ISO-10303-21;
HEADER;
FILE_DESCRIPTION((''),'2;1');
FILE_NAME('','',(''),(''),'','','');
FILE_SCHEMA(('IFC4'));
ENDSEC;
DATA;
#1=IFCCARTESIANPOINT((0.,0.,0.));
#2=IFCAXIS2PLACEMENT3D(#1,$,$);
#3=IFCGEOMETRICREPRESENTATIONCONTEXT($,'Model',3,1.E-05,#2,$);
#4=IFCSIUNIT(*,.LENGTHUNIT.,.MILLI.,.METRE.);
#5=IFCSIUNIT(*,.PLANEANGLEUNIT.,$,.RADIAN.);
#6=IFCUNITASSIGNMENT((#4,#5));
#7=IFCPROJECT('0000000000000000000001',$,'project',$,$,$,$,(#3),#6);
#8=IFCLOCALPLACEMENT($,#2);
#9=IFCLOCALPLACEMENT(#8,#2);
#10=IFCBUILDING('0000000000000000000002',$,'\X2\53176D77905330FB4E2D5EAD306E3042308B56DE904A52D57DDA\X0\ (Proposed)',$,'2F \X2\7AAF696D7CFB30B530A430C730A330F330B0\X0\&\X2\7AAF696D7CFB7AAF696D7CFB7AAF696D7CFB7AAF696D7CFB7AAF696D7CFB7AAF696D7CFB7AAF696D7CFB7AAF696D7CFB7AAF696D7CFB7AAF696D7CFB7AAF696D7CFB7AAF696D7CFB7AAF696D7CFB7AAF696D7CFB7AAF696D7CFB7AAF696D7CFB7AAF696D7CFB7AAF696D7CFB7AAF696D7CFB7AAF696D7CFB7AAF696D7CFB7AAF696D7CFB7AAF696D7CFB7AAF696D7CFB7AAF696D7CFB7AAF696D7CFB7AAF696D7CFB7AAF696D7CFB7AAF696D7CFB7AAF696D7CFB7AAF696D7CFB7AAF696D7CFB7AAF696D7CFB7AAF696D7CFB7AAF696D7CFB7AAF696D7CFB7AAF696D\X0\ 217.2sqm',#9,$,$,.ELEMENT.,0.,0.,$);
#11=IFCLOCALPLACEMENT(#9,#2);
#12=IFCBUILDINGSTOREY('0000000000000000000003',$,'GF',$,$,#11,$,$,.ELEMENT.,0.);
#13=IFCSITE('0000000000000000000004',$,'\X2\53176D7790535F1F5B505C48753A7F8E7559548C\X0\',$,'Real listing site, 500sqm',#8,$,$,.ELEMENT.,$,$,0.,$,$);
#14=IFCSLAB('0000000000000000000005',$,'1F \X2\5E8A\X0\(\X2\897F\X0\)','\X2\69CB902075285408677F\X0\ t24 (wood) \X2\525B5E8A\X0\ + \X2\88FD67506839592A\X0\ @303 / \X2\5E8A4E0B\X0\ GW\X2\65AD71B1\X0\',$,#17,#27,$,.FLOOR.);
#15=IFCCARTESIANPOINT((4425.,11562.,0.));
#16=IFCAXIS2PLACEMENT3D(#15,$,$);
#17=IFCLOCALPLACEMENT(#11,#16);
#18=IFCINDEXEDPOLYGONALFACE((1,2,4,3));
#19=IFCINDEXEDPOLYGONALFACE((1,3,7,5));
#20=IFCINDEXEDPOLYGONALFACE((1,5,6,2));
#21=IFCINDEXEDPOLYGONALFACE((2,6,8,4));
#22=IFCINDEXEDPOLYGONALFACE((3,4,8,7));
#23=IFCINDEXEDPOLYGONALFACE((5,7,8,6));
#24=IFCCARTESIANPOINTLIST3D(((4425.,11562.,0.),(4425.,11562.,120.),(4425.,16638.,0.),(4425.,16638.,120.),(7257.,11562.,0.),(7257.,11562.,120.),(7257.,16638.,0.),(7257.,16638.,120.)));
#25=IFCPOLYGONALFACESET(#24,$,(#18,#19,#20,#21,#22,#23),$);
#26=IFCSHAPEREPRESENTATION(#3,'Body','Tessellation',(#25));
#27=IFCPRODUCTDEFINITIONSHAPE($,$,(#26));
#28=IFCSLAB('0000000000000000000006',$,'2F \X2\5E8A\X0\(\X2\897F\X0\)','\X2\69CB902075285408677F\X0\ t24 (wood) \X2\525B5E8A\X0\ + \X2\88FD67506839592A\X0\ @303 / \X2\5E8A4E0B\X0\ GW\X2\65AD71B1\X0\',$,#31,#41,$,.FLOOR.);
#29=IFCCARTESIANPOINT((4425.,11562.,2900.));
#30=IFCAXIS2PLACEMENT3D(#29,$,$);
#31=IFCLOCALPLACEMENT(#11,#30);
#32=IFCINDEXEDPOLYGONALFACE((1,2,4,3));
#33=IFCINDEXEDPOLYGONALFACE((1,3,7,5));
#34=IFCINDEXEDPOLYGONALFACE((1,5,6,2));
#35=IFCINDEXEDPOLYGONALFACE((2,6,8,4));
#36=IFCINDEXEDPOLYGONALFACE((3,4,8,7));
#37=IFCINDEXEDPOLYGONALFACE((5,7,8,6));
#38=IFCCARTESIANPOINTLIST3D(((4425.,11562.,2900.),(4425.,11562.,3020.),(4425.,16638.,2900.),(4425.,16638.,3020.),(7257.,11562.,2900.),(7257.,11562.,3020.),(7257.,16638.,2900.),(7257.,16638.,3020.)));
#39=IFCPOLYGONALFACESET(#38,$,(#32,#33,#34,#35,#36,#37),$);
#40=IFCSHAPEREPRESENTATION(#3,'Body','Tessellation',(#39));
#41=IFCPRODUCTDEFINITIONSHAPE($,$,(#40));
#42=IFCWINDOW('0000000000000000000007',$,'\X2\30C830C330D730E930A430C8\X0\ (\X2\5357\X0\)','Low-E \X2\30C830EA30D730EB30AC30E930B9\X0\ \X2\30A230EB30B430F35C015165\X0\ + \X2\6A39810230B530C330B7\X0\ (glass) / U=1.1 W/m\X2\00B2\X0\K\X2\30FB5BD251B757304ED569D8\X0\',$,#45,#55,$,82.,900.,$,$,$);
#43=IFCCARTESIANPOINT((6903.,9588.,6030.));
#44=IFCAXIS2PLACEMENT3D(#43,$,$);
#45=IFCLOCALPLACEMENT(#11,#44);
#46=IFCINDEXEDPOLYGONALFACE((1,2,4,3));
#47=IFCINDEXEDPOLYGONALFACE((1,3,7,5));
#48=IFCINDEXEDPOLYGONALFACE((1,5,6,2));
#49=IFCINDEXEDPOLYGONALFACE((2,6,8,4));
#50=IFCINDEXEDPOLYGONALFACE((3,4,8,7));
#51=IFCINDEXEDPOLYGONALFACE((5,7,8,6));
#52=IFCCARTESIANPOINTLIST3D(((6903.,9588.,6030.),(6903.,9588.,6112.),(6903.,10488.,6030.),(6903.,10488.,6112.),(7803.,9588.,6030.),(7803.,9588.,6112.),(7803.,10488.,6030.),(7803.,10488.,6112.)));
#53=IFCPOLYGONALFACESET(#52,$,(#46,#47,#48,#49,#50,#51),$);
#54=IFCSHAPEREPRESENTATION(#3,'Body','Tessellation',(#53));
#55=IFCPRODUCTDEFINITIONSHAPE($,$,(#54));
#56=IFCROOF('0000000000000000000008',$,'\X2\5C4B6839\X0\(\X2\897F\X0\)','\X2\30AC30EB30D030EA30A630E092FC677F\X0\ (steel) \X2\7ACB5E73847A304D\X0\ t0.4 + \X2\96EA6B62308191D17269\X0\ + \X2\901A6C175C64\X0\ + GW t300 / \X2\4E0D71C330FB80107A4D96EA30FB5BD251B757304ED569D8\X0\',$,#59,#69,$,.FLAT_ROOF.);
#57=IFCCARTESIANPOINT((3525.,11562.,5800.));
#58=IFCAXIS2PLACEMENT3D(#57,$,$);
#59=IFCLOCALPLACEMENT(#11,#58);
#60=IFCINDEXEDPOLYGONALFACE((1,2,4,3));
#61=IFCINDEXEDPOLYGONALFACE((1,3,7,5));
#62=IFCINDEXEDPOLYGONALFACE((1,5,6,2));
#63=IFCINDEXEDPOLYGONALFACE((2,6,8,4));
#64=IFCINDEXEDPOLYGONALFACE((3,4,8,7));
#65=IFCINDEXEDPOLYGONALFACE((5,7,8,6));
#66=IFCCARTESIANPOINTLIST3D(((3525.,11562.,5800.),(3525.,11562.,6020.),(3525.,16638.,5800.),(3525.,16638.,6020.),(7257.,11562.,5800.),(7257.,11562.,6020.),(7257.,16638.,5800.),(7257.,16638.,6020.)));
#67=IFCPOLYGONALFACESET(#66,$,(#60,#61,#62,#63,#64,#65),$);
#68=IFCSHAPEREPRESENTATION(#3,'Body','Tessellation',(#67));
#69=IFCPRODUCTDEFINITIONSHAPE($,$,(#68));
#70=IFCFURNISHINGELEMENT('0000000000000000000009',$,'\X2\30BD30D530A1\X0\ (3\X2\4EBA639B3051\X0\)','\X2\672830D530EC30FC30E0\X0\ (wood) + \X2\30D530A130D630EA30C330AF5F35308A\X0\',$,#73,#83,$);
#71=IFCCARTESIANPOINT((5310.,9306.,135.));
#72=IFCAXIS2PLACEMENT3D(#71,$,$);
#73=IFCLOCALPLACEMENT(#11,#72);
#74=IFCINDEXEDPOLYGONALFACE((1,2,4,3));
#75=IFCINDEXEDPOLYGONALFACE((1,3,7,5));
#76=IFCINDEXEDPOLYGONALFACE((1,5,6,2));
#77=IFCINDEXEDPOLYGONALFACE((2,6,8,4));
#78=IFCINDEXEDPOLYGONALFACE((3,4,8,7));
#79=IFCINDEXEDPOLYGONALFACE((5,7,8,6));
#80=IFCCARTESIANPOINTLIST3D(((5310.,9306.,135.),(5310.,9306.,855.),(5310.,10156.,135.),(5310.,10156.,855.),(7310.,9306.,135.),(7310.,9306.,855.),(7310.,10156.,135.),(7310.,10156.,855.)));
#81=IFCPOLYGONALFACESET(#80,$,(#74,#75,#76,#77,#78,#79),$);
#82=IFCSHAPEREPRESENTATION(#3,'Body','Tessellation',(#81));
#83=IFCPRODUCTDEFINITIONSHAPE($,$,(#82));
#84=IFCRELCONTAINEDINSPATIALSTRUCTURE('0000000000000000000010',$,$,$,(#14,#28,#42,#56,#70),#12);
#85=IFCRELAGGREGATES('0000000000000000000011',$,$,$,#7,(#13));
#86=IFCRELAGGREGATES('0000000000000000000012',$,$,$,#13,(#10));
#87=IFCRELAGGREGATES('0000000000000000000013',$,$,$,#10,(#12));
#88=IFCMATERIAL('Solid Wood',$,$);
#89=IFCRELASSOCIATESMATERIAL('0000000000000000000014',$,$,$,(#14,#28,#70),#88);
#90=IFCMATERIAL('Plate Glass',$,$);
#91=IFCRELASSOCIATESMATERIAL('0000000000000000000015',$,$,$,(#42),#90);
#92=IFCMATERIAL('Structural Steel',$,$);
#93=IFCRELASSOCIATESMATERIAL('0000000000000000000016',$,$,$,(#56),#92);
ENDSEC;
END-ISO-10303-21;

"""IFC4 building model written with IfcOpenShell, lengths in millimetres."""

from ifc_helpers import new_model, si_unit, frame, frame_2d, origin, place, context, project, spatial, rectangle, extrude, material, element, save


model = new_model("IFC4")

# Units and contexts
model_context = context("Model", 3, precision=1e-05, world=origin())
ifc_project = project(units=[si_unit("LENGTHUNIT", "METRE", prefix="MILLI"), si_unit("PLANEANGLEUNIT", "RADIAN")], contexts=[model_context])

# Site, building, storey
site_placement = place(None, origin())
site = spatial("IfcSite", under=ifc_project, at=site_placement, Name="北海道弟子屈町美留和", ObjectType="Real listing site, 500sqm", CompositionType="ELEMENT", RefElevation=0.0)
building_placement = place(site_placement, origin())
building = spatial("IfcBuilding", under=site, at=building_placement, Name="北海道・中庭のある回遊動線 (Proposed)", ObjectType="2F 窯業系サイディング&窯業系窯業系窯業系窯業系窯業系窯業系窯業系窯業系窯業系窯業系窯業系窯業系窯業系窯業系窯業系窯業系窯業系窯業系窯業系窯業系窯業系窯業系窯業系窯業系窯業系窯業系窯業系窯業系窯業系窯業系窯業系窯業系窯業系窯業系窯業系窯業系窯業 217.2sqm", CompositionType="ELEMENT", ElevationOfRefHeight=0.0, ElevationOfTerrain=0.0)
storey_placement = place(building_placement, origin())
storey = spatial("IfcBuildingStorey", under=building, at=storey_placement, Name="GF", CompositionType="ELEMENT", Elevation=0.0)

# Shared definitions
ifc_material_1 = material(Name="Solid Wood")

# Slabs
slab_1_placement = place(storey_placement, frame((4425.0, 11562.0, 0.0)))
element("IfcSlab", 1, at=slab_1_placement, inside=storey, material=ifc_material_1, Name="1F 床(西)", Description="構造用合板 t24 (wood) 剛床 + 製材根太 @303 / 床下 GW断熱", PredefinedType="FLOOR", context=model_context, shape_type="SweptSolid", body=[
    extrude(rectangle(XDim=2832.0, YDim=5076.0, at=frame_2d((1416.0, 2538.0))), frame((4425.0, 11562.0, 0.0)), (0.0, 0.0, 1.0), 120.0),
])
slab_2_placement = place(storey_placement, frame((4425.0, 11562.0, 2900.0)))
element("IfcSlab", 2, at=slab_2_placement, inside=storey, material=ifc_material_1, Name="2F 床(西)", Description="構造用合板 t24 (wood) 剛床 + 製材根太 @303 / 床下 GW断熱", PredefinedType="FLOOR", context=model_context, shape_type="SweptSolid", body=[
    extrude(rectangle(XDim=2832.0, YDim=5076.0, at=frame_2d((1416.0, 2538.0))), frame((4425.0, 11562.0, 2900.0)), (0.0, 0.0, 1.0), 120.0),
])

# Window
ifc_material_2 = material(Name="Plate Glass")
window_placement = place(storey_placement, frame((6903.0, 9588.0, 6030.0)))
element("IfcWindow", 3, at=window_placement, inside=storey, material=ifc_material_2, Name="トップライト (南)", Description="Low-E トリプルガラス アルゴン封入 + 樹脂サッシ (glass) / U=1.1 W/m²K・寒冷地仕様", OverallHeight=82.0, OverallWidth=900.0, context=model_context, shape_type="SweptSolid", body=[
    extrude(rectangle(XDim=900.0, YDim=900.0, at=frame_2d((450.0, 450.0))), frame((6903.0, 9588.0, 6030.0)), (0.0, 0.0, 1.0), 82.0),
])

# Roof
ifc_material_3 = material(Name="Structural Steel")
for number, where, name in (
    (4, (3525.0, 11562.0, 5800.0), "屋根(西)"),
):
    element("IfcRoof", number, at=place(storey_placement, frame(where)), inside=storey, material=ifc_material_3, Name=name, Description="ガルバリウム鋼板 (steel) 立平葺き t0.4 + 雪止め金物 + 通気層 + GW t300 / 不燃・耐積雪・寒冷地仕様", PredefinedType="FLAT_ROOF", context=model_context, shape_type="SweptSolid", body=[
        extrude(rectangle(XDim=3732.0, YDim=5076.0, at=frame_2d((1866.0, 2538.0))), frame((3525.0, 11562.0, 5800.0)), (0.0, 0.0, 1.0), 220.0),
    ])

# Furnishing element
furnishing_placement = place(storey_placement, frame((5310.0, 9306.0, 135.0)))
element("IfcFurnishingElement", 5, at=furnishing_placement, inside=storey, material=ifc_material_1, Name="ソファ (3人掛け)", Description="木フレーム (wood) + ファブリック張り", context=model_context, shape_type="SweptSolid", body=[
    extrude(rectangle(XDim=2000.0, YDim=850.0, at=frame_2d((1000.0, 425.0))), frame((5310.0, 9306.0, 135.0)), (0.0, 0.0, 1.0), 720.0),
])

save(model, "model.ifc")
